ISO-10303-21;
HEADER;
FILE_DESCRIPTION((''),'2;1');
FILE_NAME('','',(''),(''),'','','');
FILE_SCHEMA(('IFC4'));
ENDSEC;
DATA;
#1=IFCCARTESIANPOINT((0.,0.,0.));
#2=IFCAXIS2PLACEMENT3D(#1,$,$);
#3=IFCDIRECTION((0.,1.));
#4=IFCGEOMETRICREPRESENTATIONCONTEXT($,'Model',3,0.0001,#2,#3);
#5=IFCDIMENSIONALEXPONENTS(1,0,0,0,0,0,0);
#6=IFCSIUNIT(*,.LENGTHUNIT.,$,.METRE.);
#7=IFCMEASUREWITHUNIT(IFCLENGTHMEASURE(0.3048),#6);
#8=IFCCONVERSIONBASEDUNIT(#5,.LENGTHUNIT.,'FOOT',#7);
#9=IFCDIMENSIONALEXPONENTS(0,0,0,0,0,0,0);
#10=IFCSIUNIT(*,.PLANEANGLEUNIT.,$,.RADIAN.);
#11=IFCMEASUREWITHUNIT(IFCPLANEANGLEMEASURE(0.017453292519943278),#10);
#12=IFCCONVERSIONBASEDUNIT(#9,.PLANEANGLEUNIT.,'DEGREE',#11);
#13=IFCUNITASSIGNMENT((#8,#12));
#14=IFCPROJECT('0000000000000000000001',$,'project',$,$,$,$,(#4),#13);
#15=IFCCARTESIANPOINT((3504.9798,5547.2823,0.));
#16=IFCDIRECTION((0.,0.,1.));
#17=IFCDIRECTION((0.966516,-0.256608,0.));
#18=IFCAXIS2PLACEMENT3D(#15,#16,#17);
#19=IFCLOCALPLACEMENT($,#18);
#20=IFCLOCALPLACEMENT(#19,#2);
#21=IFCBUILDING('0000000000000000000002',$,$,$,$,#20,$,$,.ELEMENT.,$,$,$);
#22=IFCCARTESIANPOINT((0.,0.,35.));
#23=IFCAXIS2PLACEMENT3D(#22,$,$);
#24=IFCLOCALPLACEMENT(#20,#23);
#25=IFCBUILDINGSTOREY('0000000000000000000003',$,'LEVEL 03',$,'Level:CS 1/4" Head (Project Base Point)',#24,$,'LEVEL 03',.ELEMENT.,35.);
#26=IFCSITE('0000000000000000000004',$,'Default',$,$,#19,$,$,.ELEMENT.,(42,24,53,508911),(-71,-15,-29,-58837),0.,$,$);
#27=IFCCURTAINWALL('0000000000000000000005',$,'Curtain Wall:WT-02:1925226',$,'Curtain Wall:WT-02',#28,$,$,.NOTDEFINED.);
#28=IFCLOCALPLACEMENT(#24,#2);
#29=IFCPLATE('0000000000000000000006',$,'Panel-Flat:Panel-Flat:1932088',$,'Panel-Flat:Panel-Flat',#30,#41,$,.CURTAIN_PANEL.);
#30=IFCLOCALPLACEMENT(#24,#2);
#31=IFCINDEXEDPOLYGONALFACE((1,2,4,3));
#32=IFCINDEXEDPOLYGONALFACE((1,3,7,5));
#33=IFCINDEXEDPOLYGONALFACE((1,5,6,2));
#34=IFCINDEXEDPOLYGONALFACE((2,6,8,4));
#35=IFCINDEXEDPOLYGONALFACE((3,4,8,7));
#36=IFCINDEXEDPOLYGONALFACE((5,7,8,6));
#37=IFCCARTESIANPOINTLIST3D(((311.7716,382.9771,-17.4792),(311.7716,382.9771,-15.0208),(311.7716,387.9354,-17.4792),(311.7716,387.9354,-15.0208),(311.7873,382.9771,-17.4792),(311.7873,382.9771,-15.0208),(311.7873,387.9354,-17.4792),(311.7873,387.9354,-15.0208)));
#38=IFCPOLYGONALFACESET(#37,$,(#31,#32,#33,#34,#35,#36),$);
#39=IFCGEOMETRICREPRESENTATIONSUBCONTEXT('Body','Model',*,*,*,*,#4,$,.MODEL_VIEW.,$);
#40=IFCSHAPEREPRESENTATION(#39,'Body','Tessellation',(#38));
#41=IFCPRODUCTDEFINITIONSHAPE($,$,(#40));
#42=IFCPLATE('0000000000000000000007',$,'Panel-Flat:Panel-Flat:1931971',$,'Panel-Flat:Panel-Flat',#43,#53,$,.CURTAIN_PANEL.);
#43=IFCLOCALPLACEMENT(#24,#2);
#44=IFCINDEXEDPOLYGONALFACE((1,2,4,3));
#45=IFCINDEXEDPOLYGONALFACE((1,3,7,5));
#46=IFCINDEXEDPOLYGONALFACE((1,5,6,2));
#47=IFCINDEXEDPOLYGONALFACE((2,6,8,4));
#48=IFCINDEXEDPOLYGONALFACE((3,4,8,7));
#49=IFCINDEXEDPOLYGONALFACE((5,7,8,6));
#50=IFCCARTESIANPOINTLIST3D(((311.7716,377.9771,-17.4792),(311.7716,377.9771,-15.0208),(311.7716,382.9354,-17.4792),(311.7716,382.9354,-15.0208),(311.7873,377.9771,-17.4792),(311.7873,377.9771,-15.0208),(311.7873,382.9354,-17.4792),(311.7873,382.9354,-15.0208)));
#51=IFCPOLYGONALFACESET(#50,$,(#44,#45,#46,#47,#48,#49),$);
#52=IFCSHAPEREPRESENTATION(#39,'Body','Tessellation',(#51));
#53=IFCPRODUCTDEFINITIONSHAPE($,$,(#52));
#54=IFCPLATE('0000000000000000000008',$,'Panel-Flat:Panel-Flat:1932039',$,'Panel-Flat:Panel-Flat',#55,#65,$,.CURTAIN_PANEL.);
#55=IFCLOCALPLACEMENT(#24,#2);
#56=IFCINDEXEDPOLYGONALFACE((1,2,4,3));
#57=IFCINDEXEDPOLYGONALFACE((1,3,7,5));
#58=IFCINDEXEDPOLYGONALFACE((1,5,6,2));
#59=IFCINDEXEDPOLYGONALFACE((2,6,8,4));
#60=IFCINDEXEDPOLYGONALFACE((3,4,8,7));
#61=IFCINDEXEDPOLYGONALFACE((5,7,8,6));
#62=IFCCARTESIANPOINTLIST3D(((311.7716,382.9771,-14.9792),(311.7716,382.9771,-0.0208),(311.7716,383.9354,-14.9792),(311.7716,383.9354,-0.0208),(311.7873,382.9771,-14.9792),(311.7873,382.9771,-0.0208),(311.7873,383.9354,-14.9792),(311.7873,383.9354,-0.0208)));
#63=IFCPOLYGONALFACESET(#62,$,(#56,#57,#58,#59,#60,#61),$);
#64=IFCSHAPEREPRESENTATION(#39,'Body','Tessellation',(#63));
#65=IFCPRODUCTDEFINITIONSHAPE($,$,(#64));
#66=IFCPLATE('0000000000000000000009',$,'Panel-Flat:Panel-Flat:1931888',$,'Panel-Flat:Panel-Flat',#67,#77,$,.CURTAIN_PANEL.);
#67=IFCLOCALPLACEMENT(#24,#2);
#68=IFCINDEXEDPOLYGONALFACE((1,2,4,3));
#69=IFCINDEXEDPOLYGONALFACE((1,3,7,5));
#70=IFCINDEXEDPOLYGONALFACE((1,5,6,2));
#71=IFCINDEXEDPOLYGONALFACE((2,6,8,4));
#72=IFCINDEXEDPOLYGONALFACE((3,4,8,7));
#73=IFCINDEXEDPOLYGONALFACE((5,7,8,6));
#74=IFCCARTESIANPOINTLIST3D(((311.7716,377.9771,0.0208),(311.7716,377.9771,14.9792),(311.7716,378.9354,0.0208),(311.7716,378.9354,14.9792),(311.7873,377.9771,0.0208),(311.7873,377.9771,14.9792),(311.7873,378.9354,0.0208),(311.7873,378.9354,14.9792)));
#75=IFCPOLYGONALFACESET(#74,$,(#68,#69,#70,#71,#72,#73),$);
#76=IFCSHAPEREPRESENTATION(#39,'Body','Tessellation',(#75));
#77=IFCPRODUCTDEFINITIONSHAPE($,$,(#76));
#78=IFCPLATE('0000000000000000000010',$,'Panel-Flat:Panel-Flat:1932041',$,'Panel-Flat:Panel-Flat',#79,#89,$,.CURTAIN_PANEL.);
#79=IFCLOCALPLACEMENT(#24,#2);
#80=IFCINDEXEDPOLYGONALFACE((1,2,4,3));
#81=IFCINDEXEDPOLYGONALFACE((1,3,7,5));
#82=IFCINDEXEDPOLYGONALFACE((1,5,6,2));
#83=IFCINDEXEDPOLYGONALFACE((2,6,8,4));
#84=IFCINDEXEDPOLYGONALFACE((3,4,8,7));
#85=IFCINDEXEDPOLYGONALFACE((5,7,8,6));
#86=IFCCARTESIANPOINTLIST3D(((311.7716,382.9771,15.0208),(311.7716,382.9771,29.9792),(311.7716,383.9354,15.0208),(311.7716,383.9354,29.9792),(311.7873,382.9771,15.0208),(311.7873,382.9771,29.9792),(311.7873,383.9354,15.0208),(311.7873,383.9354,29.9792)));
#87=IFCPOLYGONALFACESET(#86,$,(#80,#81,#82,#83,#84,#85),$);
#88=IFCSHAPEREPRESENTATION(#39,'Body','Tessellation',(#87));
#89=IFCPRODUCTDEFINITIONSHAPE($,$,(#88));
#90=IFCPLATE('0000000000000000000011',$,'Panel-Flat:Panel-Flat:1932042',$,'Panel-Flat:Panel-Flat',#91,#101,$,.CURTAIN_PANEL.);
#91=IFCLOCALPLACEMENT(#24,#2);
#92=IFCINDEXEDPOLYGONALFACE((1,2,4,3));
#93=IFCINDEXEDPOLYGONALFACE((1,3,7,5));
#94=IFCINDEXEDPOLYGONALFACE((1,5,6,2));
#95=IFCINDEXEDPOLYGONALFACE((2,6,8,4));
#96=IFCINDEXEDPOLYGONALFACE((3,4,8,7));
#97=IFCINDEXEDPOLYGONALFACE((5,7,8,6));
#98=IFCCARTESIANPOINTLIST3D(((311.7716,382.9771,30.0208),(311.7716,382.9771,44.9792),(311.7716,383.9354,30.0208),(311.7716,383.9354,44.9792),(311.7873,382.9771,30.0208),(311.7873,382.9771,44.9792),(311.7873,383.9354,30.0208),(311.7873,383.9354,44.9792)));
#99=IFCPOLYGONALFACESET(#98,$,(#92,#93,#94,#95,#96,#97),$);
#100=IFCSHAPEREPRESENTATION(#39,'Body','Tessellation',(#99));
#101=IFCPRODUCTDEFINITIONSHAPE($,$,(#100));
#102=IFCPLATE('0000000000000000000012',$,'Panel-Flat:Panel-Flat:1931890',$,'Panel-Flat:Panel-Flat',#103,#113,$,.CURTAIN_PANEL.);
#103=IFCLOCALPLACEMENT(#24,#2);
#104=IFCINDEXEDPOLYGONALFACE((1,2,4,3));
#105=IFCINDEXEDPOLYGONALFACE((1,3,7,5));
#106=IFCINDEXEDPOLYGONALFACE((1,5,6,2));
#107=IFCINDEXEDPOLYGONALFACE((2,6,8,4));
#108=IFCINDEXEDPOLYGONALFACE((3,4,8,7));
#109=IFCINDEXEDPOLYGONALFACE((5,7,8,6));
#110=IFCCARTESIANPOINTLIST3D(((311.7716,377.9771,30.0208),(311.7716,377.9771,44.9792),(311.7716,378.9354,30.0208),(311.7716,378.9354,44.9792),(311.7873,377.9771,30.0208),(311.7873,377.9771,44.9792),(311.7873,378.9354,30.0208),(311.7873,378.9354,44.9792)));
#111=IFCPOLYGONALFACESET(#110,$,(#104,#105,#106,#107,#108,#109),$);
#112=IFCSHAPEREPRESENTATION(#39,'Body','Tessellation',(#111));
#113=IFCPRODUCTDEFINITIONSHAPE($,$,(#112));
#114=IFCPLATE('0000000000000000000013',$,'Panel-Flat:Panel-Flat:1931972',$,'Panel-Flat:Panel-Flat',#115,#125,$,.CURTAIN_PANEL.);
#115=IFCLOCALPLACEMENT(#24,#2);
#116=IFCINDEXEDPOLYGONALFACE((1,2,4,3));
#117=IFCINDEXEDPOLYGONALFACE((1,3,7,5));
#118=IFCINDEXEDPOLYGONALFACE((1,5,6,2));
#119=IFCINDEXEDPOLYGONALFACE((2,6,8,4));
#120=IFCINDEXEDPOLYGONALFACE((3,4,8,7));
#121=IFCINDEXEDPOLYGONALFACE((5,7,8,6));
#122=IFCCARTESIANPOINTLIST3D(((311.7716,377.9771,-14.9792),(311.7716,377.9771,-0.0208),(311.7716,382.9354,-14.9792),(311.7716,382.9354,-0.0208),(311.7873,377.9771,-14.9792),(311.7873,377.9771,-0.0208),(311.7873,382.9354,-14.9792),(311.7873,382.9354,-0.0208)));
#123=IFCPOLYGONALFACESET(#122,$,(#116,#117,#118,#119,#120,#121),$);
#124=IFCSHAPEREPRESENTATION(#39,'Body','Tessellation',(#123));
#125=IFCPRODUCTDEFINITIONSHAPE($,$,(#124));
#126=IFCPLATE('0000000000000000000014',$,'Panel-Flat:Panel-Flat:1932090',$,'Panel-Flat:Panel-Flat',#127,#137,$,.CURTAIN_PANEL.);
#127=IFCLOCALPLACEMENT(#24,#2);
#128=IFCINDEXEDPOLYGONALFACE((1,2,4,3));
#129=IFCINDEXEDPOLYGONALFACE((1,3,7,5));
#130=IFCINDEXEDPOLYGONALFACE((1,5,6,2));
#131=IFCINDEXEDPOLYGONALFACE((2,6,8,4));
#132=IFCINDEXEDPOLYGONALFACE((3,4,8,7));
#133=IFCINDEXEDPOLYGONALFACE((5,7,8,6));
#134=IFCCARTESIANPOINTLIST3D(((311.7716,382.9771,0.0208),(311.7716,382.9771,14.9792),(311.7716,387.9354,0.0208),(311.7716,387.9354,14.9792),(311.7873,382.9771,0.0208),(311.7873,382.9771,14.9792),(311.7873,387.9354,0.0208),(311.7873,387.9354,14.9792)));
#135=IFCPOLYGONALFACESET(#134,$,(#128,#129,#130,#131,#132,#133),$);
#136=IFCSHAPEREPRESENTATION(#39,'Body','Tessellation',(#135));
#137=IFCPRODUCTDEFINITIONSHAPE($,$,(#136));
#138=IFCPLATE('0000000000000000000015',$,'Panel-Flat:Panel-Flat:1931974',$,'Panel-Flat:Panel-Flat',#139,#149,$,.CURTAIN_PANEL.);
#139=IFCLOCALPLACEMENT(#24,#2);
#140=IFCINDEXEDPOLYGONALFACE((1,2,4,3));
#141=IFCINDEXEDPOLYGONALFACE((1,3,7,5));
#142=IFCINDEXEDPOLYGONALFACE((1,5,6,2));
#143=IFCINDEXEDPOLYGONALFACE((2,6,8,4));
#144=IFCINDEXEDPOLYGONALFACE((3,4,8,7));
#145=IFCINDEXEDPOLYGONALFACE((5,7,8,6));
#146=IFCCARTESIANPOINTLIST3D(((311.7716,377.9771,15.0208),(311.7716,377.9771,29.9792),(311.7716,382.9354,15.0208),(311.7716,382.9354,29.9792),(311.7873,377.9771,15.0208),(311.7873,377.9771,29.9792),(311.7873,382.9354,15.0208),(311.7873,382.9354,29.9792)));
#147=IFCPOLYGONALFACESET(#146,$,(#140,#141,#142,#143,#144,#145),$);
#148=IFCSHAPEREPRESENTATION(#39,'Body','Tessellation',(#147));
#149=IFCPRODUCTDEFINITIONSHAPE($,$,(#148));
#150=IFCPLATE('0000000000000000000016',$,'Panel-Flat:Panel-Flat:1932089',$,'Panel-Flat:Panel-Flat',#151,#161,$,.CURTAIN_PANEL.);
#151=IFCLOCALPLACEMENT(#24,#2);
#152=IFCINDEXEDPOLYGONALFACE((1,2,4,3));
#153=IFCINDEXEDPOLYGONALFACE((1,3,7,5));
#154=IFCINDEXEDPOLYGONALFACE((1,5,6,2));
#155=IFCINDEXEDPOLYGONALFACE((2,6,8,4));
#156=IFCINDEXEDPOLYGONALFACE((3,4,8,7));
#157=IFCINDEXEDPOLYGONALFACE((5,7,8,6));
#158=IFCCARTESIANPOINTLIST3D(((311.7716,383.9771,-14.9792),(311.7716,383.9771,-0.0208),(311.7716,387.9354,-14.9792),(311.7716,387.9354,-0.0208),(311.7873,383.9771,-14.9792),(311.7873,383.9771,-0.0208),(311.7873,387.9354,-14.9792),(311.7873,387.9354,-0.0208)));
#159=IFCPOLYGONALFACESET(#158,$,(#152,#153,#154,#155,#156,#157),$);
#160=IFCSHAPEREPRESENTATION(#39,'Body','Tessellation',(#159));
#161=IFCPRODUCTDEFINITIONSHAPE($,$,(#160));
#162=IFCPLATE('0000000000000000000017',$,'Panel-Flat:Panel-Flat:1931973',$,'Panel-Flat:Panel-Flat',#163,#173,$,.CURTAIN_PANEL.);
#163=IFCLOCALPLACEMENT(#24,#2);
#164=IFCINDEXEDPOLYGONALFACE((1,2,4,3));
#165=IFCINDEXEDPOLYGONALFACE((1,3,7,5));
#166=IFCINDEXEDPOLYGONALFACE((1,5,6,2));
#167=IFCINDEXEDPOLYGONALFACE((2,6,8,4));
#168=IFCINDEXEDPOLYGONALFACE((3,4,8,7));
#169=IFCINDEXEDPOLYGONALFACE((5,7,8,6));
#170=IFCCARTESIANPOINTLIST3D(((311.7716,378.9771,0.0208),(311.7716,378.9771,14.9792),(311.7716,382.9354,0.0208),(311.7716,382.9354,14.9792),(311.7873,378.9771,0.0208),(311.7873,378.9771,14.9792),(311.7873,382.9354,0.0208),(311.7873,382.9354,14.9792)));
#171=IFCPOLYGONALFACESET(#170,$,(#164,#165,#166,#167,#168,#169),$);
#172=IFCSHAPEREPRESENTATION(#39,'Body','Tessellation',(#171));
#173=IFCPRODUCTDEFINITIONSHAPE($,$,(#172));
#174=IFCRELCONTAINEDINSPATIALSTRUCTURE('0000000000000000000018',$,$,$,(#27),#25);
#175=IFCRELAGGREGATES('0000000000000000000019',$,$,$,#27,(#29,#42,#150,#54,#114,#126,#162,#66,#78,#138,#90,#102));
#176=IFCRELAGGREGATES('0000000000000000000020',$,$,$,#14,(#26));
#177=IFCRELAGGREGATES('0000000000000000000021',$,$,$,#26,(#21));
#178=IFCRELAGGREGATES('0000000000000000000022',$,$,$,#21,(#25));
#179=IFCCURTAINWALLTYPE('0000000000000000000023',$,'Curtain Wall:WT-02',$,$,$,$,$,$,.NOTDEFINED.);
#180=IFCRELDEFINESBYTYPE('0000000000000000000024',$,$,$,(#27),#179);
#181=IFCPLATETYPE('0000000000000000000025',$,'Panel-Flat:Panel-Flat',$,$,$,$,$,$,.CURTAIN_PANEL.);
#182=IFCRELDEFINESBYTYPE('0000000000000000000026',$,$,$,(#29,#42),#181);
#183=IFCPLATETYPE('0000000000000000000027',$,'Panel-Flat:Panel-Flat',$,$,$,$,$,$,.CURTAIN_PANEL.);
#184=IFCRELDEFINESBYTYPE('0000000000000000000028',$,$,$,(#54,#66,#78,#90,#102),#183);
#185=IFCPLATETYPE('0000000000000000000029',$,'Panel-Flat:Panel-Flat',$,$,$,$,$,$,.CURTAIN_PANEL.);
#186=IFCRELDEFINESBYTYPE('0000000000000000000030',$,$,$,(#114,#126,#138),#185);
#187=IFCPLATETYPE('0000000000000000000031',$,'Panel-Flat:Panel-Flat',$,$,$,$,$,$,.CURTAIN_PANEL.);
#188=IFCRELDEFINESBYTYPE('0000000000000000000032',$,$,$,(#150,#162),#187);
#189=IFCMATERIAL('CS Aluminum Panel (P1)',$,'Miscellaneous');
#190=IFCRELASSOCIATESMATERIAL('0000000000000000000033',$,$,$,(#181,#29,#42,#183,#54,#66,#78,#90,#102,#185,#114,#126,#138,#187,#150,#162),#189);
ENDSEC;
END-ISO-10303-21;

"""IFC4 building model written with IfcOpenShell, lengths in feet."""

from ifc_helpers import new_model, entity, si_unit, converted_unit, direction, frame, origin, place, context, subcontext, project, spatial, indexed_curve, outline, extrude, source, transform, mapped, material, type_object, type_shapes, element, aggregate, save


model = new_model("IFC4")

# Units and contexts
model_context = context("Model", 3, precision=0.0001, world=origin(), true_north=direction((0.0, 1.0)))
body_context = subcontext(model_context, "Body", "Model", "MODEL_VIEW")
ifc_project = project(units=[converted_unit("LENGTHUNIT", "FOOT", entity("IfcLengthMeasure", 0.3048), si_unit("LENGTHUNIT", "METRE"), dimensions=[1, 0, 0, 0, 0, 0, 0]), converted_unit("PLANEANGLEUNIT", "DEGREE", entity("IfcPlaneAngleMeasure", 0.017453292519943278), si_unit("PLANEANGLEUNIT", "RADIAN"), dimensions=[0, 0, 0, 0, 0, 0, 0])], contexts=[model_context])

# Site, building, storey
site_placement = place(None, frame((3504.9798, 5547.2823, 0.0), z_axis=(0.0, 0.0, 1.0), x_axis=(0.966516, -0.256608, 0.0)))
site = spatial("IfcSite", under=ifc_project, at=site_placement, Name="Default", CompositionType="ELEMENT", RefLatitude=(42, 24, 53, 508911), RefLongitude=(-71, -15, -29, -58837), RefElevation=0.0)
building_placement = place(site_placement, origin())
building = spatial("IfcBuilding", under=site, at=building_placement, CompositionType="ELEMENT")
storey_placement = place(building_placement, frame((0.0, 0.0, 35.0)))
storey = spatial("IfcBuildingStorey", under=building, at=storey_placement, Name="LEVEL 03", ObjectType="Level:CS 1/4\" Head (Project Base Point)", LongName="LEVEL 03", CompositionType="ELEMENT", Elevation=35.0)

# Curtain wall, plates
curtain_wall_type = type_object("IfcCurtainWallType", Name="Curtain Wall:WT-02", PredefinedType="NOTDEFINED")
curtain_wall_1_placement = place(storey_placement, frame((0.0, 0.0, -35.0)))
curtain_wall_1 = element("IfcCurtainWall", 1, at=curtain_wall_1_placement, inside=storey, type_object=curtain_wall_type, Name="Curtain Wall:WT-02:1925226", ObjectType="Curtain Wall:WT-02", PredefinedType="NOTDEFINED")
ifc_material_1 = material(Name="CS Aluminum Panel (P1)", Category="Miscellaneous")
plate_type_1 = type_object("IfcPlateType", Name="Panel-Flat:Panel-Flat", PredefinedType="CURTAIN_PANEL", material=ifc_material_1)
shared_shape_1 = source(origin(), body_context, "Body", "SweptSolid", [
    extrude(outline(indexed_curve([(-0.0078, -2.4792), (0.0078, -2.4792), (0.0078, 2.4792), (-0.0078, 2.4792), (-0.0078, -2.4792)], self_intersect=False)), frame((2.4792, 0.0078, 0.0), z_axis=(0.0, 0.0, 1.0), x_axis=(0.0, -1.0, 0.0)), (0.0, 0.0, 1.0), 2.4583),
])
type_shapes(plate_type_1, [shared_shape_1])
plate_1_placement = place(curtain_wall_1_placement, frame((311.7716, 387.9354, 17.5208), z_axis=(0.0, 0.0, 1.0), x_axis=(0.0, -1.0, 0.0)))
plate_1 = element("IfcPlate", 2, at=plate_1_placement, type_object=plate_type_1, material=ifc_material_1, Name="Panel-Flat:Panel-Flat:1932088", ObjectType="Panel-Flat:Panel-Flat", PredefinedType="CURTAIN_PANEL", context=body_context, shape_type="MappedRepresentation", body=[
    mapped(shared_shape_1, transform((0.0, 0.0, 0.0), scale=1.0)),
])
plate_2_placement = place(curtain_wall_1_placement, frame((311.7716, 382.9354, 17.5208), z_axis=(0.0, 0.0, 1.0), x_axis=(0.0, -1.0, 0.0)))
plate_2 = element("IfcPlate", 3, at=plate_2_placement, type_object=plate_type_1, material=ifc_material_1, Name="Panel-Flat:Panel-Flat:1931971", ObjectType="Panel-Flat:Panel-Flat", PredefinedType="CURTAIN_PANEL", context=body_context, shape_type="MappedRepresentation", body=[
    mapped(shared_shape_1, transform((0.0, 0.0, 0.0), scale=1.0)),
])
plate_type_2 = type_object("IfcPlateType", Name="Panel-Flat:Panel-Flat", PredefinedType="CURTAIN_PANEL", material=ifc_material_1)
shared_shape_2 = source(origin(), body_context, "Body", "SweptSolid", [
    extrude(outline(indexed_curve([(-0.0078, -0.4792), (0.0078, -0.4792), (0.0078, 0.4792), (-0.0078, 0.4792), (-0.0078, -0.4792)], self_intersect=False)), frame((0.4792, 0.0078, 0.0), z_axis=(0.0, 0.0, 1.0), x_axis=(0.0, -1.0, 0.0)), (0.0, 0.0, 1.0), 14.9583),
])
type_shapes(plate_type_2, [shared_shape_2])
plate_3_placement = place(curtain_wall_1_placement, frame((311.7716, 383.9354, 20.0208), z_axis=(0.0, 0.0, 1.0), x_axis=(0.0, -1.0, 0.0)))
plate_3 = element("IfcPlate", 4, at=plate_3_placement, type_object=plate_type_2, material=ifc_material_1, Name="Panel-Flat:Panel-Flat:1932039", ObjectType="Panel-Flat:Panel-Flat", PredefinedType="CURTAIN_PANEL", context=body_context, shape_type="MappedRepresentation", body=[
    mapped(shared_shape_2, transform((0.0, 0.0, 0.0), scale=1.0)),
])
plate_4_placement = place(curtain_wall_1_placement, frame((311.7716, 378.9354, 35.0208), z_axis=(0.0, 0.0, 1.0), x_axis=(0.0, -1.0, 0.0)))
plate_4 = element("IfcPlate", 5, at=plate_4_placement, type_object=plate_type_2, material=ifc_material_1, Name="Panel-Flat:Panel-Flat:1931888", ObjectType="Panel-Flat:Panel-Flat", PredefinedType="CURTAIN_PANEL", context=body_context, shape_type="MappedRepresentation", body=[
    mapped(shared_shape_2, transform((0.0, 0.0, 0.0), scale=1.0)),
])
plate_5_placement = place(curtain_wall_1_placement, frame((311.7716, 383.9354, 50.0208), z_axis=(0.0, 0.0, 1.0), x_axis=(0.0, -1.0, 0.0)))
plate_5 = element("IfcPlate", 6, at=plate_5_placement, type_object=plate_type_2, material=ifc_material_1, Name="Panel-Flat:Panel-Flat:1932041", ObjectType="Panel-Flat:Panel-Flat", PredefinedType="CURTAIN_PANEL", context=body_context, shape_type="MappedRepresentation", body=[
    mapped(shared_shape_2, transform((0.0, 0.0, 0.0), scale=1.0)),
])
plate_6_placement = place(curtain_wall_1_placement, frame((311.7716, 383.9354, 65.0208), z_axis=(0.0, 0.0, 1.0), x_axis=(0.0, -1.0, 0.0)))
plate_6 = element("IfcPlate", 7, at=plate_6_placement, type_object=plate_type_2, material=ifc_material_1, Name="Panel-Flat:Panel-Flat:1932042", ObjectType="Panel-Flat:Panel-Flat", PredefinedType="CURTAIN_PANEL", context=body_context, shape_type="MappedRepresentation", body=[
    mapped(shared_shape_2, transform((0.0, 0.0, 0.0), scale=1.0)),
])
plate_7_placement = place(curtain_wall_1_placement, frame((311.7716, 378.9354, 65.0208), z_axis=(0.0, 0.0, 1.0), x_axis=(0.0, -1.0, 0.0)))
plate_7 = element("IfcPlate", 8, at=plate_7_placement, type_object=plate_type_2, material=ifc_material_1, Name="Panel-Flat:Panel-Flat:1931890", ObjectType="Panel-Flat:Panel-Flat", PredefinedType="CURTAIN_PANEL", context=body_context, shape_type="MappedRepresentation", body=[
    mapped(shared_shape_2, transform((0.0, 0.0, 0.0), scale=1.0)),
])
plate_type_3 = type_object("IfcPlateType", Name="Panel-Flat:Panel-Flat", PredefinedType="CURTAIN_PANEL", material=ifc_material_1)
shared_shape_3 = source(origin(), body_context, "Body", "SweptSolid", [
    extrude(outline(indexed_curve([(-0.0078, -2.4792), (0.0078, -2.4792), (0.0078, 2.4792), (-0.0078, 2.4792), (-0.0078, -2.4792)], self_intersect=False)), frame((2.4792, 0.0078, 0.0), z_axis=(0.0, 0.0, 1.0), x_axis=(0.0, -1.0, 0.0)), (0.0, 0.0, 1.0), 14.9583),
])
type_shapes(plate_type_3, [shared_shape_3])
plate_8_placement = place(curtain_wall_1_placement, frame((311.7716, 382.9354, 20.0208), z_axis=(0.0, 0.0, 1.0), x_axis=(0.0, -1.0, 0.0)))
plate_8 = element("IfcPlate", 9, at=plate_8_placement, type_object=plate_type_3, material=ifc_material_1, Name="Panel-Flat:Panel-Flat:1931972", ObjectType="Panel-Flat:Panel-Flat", PredefinedType="CURTAIN_PANEL", context=body_context, shape_type="MappedRepresentation", body=[
    mapped(shared_shape_3, transform((0.0, 0.0, 0.0), scale=1.0)),
])
plate_9_placement = place(curtain_wall_1_placement, frame((311.7716, 387.9354, 35.0208), z_axis=(0.0, 0.0, 1.0), x_axis=(0.0, -1.0, 0.0)))
plate_9 = element("IfcPlate", 10, at=plate_9_placement, type_object=plate_type_3, material=ifc_material_1, Name="Panel-Flat:Panel-Flat:1932090", ObjectType="Panel-Flat:Panel-Flat", PredefinedType="CURTAIN_PANEL", context=body_context, shape_type="MappedRepresentation", body=[
    mapped(shared_shape_3, transform((0.0, 0.0, 0.0), scale=1.0)),
])
plate_10_placement = place(curtain_wall_1_placement, frame((311.7716, 382.9354, 50.0208), z_axis=(0.0, 0.0, 1.0), x_axis=(0.0, -1.0, 0.0)))
plate_10 = element("IfcPlate", 11, at=plate_10_placement, type_object=plate_type_3, material=ifc_material_1, Name="Panel-Flat:Panel-Flat:1931974", ObjectType="Panel-Flat:Panel-Flat", PredefinedType="CURTAIN_PANEL", context=body_context, shape_type="MappedRepresentation", body=[
    mapped(shared_shape_3, transform((0.0, 0.0, 0.0), scale=1.0)),
])
plate_type_4 = type_object("IfcPlateType", Name="Panel-Flat:Panel-Flat", PredefinedType="CURTAIN_PANEL", material=ifc_material_1)
shared_shape_4 = source(origin(), body_context, "Body", "SweptSolid", [
    extrude(outline(indexed_curve([(-0.0078, -1.9792), (0.0078, -1.9792), (0.0078, 1.9792), (-0.0078, 1.9792), (-0.0078, -1.9792)], self_intersect=False)), frame((1.9792, 0.0078, 0.0), z_axis=(0.0, 0.0, 1.0), x_axis=(0.0, -1.0, 0.0)), (0.0, 0.0, 1.0), 14.9583),
])
type_shapes(plate_type_4, [shared_shape_4])
plate_11_placement = place(curtain_wall_1_placement, frame((311.7716, 387.9354, 20.0208), z_axis=(0.0, 0.0, 1.0), x_axis=(0.0, -1.0, 0.0)))
plate_11 = element("IfcPlate", 12, at=plate_11_placement, type_object=plate_type_4, material=ifc_material_1, Name="Panel-Flat:Panel-Flat:1932089", ObjectType="Panel-Flat:Panel-Flat", PredefinedType="CURTAIN_PANEL", context=body_context, shape_type="MappedRepresentation", body=[
    mapped(shared_shape_4, transform((0.0, 0.0, 0.0), scale=1.0)),
])
plate_12_placement = place(curtain_wall_1_placement, frame((311.7716, 382.9354, 35.0208), z_axis=(0.0, 0.0, 1.0), x_axis=(0.0, -1.0, 0.0)))
plate_12 = element("IfcPlate", 13, at=plate_12_placement, type_object=plate_type_4, material=ifc_material_1, Name="Panel-Flat:Panel-Flat:1931973", ObjectType="Panel-Flat:Panel-Flat", PredefinedType="CURTAIN_PANEL", context=body_context, shape_type="MappedRepresentation", body=[
    mapped(shared_shape_4, transform((0.0, 0.0, 0.0), scale=1.0)),
])
aggregate(curtain_wall_1, [plate_1, plate_2, plate_11, plate_3, plate_8, plate_9, plate_12, plate_4, plate_5, plate_10, plate_6, plate_7])

save(model, "model.ifc")
